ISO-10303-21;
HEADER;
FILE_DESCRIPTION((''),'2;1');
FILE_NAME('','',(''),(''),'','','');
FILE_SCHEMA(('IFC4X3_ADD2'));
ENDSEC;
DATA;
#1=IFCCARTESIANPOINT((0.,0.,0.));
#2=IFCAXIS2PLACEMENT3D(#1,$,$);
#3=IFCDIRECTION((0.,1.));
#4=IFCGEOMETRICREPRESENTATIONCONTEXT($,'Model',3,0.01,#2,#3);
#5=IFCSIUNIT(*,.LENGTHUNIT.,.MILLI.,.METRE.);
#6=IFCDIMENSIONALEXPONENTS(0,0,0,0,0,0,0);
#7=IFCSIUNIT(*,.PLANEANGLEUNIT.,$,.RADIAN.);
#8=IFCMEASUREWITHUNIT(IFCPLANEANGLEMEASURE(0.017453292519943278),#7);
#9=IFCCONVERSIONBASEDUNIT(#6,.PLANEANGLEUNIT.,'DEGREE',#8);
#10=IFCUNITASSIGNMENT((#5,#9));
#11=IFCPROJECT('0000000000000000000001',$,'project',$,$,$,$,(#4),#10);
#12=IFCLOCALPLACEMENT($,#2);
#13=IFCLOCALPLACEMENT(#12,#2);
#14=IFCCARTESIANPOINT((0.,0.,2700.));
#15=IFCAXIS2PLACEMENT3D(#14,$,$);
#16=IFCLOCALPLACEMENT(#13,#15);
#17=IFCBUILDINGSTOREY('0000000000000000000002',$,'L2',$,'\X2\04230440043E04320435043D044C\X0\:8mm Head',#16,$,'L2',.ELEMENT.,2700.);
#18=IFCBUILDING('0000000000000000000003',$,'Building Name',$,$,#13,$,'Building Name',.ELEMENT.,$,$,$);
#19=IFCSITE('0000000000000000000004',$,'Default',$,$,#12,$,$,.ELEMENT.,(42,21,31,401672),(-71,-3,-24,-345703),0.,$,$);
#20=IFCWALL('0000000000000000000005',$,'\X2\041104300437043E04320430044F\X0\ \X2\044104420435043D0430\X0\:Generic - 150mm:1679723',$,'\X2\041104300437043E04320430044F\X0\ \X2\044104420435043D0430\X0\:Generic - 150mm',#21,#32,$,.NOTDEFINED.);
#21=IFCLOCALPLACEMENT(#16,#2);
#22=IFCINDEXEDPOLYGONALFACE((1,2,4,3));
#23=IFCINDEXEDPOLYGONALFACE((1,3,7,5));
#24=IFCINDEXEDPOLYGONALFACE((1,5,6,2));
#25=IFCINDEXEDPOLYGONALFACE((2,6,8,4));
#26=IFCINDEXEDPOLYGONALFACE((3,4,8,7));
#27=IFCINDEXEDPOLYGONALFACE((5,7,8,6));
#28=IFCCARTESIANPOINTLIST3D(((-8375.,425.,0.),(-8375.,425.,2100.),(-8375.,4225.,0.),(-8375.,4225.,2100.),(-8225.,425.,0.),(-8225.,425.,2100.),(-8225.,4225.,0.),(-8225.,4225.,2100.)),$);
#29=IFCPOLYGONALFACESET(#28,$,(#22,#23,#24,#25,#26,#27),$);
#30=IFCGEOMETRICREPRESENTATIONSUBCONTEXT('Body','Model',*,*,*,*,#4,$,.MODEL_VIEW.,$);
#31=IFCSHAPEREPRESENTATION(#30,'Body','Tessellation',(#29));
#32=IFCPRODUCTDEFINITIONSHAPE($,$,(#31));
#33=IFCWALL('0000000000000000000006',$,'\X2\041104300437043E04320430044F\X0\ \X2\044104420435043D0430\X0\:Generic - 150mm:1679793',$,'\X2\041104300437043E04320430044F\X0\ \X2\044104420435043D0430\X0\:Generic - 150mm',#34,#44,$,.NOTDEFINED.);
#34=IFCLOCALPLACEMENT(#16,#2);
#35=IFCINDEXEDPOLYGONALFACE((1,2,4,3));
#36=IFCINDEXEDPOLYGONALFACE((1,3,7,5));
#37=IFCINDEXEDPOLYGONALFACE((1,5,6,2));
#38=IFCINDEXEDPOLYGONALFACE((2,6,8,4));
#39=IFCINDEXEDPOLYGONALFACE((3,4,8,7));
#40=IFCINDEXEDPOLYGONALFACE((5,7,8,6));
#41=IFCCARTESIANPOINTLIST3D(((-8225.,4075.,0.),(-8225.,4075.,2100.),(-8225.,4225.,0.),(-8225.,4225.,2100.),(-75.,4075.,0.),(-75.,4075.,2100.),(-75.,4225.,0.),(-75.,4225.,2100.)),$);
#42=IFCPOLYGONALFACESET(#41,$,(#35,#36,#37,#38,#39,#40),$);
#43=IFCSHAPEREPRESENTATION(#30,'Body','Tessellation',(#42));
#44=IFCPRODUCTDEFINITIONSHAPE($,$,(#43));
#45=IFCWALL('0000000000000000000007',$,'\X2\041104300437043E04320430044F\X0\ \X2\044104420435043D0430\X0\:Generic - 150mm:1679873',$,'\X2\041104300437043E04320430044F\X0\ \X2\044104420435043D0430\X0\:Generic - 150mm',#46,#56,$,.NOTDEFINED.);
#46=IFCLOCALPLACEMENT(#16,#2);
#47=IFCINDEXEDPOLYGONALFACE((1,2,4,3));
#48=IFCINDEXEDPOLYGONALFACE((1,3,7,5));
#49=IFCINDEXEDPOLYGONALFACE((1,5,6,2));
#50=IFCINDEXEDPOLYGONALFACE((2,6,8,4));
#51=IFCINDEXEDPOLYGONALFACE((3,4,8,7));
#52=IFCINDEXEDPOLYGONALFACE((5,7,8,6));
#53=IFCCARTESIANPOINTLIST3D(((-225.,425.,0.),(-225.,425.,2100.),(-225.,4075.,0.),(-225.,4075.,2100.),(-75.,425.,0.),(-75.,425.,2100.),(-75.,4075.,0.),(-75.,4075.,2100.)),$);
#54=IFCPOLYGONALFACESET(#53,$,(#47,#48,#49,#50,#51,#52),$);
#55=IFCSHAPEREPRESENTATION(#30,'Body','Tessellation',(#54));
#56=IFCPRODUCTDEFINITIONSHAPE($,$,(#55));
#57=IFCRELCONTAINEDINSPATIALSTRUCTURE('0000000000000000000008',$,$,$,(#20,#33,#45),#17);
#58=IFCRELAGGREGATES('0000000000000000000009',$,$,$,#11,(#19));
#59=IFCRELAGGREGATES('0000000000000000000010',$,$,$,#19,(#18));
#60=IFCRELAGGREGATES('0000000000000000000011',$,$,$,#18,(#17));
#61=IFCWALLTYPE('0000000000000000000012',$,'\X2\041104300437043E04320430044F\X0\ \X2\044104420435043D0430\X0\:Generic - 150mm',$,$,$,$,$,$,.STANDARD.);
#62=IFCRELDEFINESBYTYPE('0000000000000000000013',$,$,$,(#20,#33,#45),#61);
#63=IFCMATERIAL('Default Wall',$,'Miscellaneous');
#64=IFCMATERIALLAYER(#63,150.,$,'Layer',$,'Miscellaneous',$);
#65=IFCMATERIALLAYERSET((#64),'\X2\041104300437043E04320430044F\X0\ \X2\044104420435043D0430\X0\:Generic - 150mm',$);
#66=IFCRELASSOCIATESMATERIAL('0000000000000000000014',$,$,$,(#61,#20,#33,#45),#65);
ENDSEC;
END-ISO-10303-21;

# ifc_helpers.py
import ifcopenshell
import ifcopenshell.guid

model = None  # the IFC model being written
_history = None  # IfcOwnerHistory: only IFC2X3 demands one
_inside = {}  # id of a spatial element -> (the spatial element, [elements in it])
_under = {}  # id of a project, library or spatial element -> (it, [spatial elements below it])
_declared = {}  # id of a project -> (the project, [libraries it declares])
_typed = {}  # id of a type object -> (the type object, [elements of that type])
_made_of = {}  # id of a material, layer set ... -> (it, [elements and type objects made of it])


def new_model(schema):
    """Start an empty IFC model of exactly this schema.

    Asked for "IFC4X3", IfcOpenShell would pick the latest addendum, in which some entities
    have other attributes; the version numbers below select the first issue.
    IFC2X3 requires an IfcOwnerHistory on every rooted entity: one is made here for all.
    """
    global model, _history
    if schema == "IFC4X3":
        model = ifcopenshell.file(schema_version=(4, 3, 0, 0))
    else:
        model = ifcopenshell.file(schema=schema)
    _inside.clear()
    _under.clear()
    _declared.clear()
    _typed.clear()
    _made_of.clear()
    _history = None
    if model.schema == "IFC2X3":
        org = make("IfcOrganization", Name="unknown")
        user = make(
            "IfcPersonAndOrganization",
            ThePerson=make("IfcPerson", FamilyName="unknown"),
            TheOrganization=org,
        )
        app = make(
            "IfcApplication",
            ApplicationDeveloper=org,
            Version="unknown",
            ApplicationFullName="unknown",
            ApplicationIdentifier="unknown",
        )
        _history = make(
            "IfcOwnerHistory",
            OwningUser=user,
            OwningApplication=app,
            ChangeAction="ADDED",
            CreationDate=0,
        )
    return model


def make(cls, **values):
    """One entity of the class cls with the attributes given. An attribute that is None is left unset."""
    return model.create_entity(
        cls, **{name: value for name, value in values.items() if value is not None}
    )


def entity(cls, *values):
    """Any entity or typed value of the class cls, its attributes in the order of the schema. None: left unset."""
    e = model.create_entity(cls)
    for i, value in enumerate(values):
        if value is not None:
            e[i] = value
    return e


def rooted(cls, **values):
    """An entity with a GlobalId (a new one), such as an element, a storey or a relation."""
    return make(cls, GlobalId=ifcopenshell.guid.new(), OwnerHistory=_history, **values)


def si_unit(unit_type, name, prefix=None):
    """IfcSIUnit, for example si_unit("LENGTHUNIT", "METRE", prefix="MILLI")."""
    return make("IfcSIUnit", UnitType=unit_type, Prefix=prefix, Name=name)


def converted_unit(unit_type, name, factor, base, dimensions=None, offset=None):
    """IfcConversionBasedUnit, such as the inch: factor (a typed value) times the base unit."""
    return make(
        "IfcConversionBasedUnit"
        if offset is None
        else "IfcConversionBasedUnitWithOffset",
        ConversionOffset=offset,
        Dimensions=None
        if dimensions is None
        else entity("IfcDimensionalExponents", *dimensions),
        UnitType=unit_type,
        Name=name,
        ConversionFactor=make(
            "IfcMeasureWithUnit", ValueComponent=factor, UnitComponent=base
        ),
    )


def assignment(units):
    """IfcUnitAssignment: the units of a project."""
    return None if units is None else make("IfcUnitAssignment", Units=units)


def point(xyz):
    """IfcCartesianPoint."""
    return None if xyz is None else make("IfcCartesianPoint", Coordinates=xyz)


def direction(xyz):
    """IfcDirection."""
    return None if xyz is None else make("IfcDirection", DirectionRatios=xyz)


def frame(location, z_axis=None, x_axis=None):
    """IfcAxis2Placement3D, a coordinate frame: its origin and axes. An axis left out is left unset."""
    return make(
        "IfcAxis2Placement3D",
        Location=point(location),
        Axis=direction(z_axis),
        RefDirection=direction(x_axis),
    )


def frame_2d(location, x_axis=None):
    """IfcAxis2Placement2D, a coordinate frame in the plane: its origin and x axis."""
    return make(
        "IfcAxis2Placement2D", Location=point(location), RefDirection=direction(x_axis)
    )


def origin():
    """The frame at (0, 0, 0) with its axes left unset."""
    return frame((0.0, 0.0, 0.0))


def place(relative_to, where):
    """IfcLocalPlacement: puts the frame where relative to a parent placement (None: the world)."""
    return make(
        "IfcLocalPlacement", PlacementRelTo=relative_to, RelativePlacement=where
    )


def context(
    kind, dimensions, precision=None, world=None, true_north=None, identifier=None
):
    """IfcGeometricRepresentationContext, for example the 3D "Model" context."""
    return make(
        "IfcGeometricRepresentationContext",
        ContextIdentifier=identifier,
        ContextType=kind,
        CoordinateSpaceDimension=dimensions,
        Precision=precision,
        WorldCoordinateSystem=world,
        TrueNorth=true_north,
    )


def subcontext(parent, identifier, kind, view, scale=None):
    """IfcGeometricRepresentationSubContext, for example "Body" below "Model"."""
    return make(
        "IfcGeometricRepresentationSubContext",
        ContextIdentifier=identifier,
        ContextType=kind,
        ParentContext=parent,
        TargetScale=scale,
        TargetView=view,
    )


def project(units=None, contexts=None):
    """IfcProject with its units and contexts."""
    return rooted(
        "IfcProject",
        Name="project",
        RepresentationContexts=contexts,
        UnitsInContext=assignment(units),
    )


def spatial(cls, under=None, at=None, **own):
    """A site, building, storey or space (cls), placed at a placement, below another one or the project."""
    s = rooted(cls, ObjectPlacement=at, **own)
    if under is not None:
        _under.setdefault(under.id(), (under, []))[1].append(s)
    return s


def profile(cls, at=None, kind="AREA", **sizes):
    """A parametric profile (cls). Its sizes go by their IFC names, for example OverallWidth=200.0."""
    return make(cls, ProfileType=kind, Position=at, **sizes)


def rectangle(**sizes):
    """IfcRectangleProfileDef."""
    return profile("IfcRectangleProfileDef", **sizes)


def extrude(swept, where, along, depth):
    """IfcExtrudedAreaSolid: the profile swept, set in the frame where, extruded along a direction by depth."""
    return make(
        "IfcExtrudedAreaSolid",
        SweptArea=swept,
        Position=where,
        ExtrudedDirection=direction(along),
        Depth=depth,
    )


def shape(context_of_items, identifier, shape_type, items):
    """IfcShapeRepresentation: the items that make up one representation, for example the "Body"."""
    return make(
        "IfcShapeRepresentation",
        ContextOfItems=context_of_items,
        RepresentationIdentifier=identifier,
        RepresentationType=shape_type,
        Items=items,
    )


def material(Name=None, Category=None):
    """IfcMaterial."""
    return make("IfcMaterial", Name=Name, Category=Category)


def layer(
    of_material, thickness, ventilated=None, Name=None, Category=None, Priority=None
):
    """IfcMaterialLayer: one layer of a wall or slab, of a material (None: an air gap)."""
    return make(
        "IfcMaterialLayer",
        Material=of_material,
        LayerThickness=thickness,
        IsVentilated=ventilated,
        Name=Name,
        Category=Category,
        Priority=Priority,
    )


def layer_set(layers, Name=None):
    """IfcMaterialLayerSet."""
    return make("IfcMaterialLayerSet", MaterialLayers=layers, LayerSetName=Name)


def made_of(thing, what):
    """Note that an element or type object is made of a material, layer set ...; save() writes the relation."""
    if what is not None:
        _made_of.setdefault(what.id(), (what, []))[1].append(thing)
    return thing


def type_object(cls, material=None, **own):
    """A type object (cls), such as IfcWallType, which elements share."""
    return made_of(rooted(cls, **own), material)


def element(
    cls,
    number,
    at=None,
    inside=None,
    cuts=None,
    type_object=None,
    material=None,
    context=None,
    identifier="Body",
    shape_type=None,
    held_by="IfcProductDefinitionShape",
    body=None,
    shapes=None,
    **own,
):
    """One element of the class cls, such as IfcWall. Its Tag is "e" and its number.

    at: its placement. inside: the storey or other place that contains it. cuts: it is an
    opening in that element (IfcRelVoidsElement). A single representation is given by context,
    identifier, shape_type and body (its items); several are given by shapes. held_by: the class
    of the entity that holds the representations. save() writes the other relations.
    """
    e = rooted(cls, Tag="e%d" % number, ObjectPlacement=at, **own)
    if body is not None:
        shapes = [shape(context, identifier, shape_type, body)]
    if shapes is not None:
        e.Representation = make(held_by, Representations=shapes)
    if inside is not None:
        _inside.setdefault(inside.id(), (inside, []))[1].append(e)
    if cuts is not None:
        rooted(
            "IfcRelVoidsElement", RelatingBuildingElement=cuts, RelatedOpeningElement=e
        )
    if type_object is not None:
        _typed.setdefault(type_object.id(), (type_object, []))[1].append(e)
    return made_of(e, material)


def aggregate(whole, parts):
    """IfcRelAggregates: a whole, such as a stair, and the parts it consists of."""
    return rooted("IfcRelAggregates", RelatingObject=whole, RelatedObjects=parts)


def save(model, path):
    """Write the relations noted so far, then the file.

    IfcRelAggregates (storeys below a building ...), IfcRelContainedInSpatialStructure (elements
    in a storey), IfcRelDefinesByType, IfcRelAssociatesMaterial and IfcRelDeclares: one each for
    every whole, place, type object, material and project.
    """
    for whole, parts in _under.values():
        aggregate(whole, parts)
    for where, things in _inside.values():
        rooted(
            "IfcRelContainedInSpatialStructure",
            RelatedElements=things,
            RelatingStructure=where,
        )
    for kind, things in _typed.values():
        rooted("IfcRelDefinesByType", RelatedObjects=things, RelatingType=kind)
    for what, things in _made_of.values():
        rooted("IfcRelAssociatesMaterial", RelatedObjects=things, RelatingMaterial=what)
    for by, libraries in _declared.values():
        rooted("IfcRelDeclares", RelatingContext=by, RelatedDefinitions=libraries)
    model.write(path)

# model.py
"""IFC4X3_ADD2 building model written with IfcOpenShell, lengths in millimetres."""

from ifc_helpers import new_model, entity, si_unit, converted_unit, direction, frame, frame_2d, origin, place, context, subcontext, project, spatial, rectangle, extrude, material, layer, layer_set, type_object, element, save


model = new_model("IFC4X3_ADD2")

# Units and contexts
model_context = context("Model", 3, precision=0.01, world=origin(), true_north=direction((0.0, 1.0)))
body_context = subcontext(model_context, "Body", "Model", "MODEL_VIEW")
ifc_project = project(units=[si_unit("LENGTHUNIT", "METRE", prefix="MILLI"), converted_unit("PLANEANGLEUNIT", "DEGREE", entity("IfcPlaneAngleMeasure", 0.017453292519943278), si_unit("PLANEANGLEUNIT", "RADIAN"), dimensions=[0, 0, 0, 0, 0, 0, 0])], contexts=[model_context])

# Site, building, storey
site_placement = place(None, origin())
site = spatial("IfcSite", under=ifc_project, at=site_placement, Name="Default", CompositionType="ELEMENT", RefLatitude=(42, 21, 31, 401672), RefLongitude=(-71, -3, -24, -345703), RefElevation=0.0)
building_placement = place(site_placement, origin())
building = spatial("IfcBuilding", under=site, at=building_placement, Name="Building Name", LongName="Building Name", CompositionType="ELEMENT")
storey_placement = place(building_placement, frame((0.0, 0.0, 2700.0)))
storey = spatial("IfcBuildingStorey", under=building, at=storey_placement, Name="L2", ObjectType="Уровень:8mm Head", LongName="L2", CompositionType="ELEMENT", Elevation=2700.0)

# Walls
ifc_material_1 = material(Name="Default Wall", Category="Miscellaneous")
ifc_layer_1 = layer(ifc_material_1, 150.0, Name="Layer", Category="Miscellaneous")
ifc_layer_set_1 = layer_set([ifc_layer_1], Name="Базовая стена:Generic - 150mm")
wall_type = type_object("IfcWallType", Name="Базовая стена:Generic - 150mm", PredefinedType="STANDARD", material=ifc_layer_set_1)
wall_1_placement = place(storey_placement, frame((-8300.0, 425.0, 0.0), z_axis=(0.0, 0.0, 1.0), x_axis=(0.0, 1.0, 0.0)))
element("IfcWall", 1, at=wall_1_placement, inside=storey, type_object=wall_type, material=ifc_layer_set_1, Name="Базовая стена:Generic - 150mm:1679723", ObjectType="Базовая стена:Generic - 150mm", PredefinedType="NOTDEFINED", context=body_context, shape_type="SweptSolid", body=[
    extrude(rectangle(XDim=3800.0, YDim=150.0, at=frame_2d((1900.0, 0.0), x_axis=(-1.0, 0.0))), origin(), (0.0, 0.0, 1.0), 2100.0),
])
wall_2_placement = place(storey_placement, frame((-8225.0, 4150.0, 0.0)))
element("IfcWall", 2, at=wall_2_placement, inside=storey, type_object=wall_type, material=ifc_layer_set_1, Name="Базовая стена:Generic - 150mm:1679793", ObjectType="Базовая стена:Generic - 150mm", PredefinedType="NOTDEFINED", context=body_context, shape_type="SweptSolid", body=[
    extrude(rectangle(XDim=8150.0, YDim=150.0, at=frame_2d((4075.0, 0.0), x_axis=(-1.0, 0.0))), origin(), (0.0, 0.0, 1.0), 2100.0),
])
wall_3_placement = place(storey_placement, frame((-150.0, 4075.0, 0.0), z_axis=(0.0, 0.0, 1.0), x_axis=(0.0, -1.0, 0.0)))
element("IfcWall", 3, at=wall_3_placement, inside=storey, type_object=wall_type, material=ifc_layer_set_1, Name="Базовая стена:Generic - 150mm:1679873", ObjectType="Базовая стена:Generic - 150mm", PredefinedType="NOTDEFINED", context=body_context, shape_type="SweptSolid", body=[
    extrude(rectangle(XDim=3650.0, YDim=150.0, at=frame_2d((1825.0, 0.0), x_axis=(-1.0, 0.0))), origin(), (0.0, 0.0, 1.0), 2100.0),
])

save(model, "model.ifc")
